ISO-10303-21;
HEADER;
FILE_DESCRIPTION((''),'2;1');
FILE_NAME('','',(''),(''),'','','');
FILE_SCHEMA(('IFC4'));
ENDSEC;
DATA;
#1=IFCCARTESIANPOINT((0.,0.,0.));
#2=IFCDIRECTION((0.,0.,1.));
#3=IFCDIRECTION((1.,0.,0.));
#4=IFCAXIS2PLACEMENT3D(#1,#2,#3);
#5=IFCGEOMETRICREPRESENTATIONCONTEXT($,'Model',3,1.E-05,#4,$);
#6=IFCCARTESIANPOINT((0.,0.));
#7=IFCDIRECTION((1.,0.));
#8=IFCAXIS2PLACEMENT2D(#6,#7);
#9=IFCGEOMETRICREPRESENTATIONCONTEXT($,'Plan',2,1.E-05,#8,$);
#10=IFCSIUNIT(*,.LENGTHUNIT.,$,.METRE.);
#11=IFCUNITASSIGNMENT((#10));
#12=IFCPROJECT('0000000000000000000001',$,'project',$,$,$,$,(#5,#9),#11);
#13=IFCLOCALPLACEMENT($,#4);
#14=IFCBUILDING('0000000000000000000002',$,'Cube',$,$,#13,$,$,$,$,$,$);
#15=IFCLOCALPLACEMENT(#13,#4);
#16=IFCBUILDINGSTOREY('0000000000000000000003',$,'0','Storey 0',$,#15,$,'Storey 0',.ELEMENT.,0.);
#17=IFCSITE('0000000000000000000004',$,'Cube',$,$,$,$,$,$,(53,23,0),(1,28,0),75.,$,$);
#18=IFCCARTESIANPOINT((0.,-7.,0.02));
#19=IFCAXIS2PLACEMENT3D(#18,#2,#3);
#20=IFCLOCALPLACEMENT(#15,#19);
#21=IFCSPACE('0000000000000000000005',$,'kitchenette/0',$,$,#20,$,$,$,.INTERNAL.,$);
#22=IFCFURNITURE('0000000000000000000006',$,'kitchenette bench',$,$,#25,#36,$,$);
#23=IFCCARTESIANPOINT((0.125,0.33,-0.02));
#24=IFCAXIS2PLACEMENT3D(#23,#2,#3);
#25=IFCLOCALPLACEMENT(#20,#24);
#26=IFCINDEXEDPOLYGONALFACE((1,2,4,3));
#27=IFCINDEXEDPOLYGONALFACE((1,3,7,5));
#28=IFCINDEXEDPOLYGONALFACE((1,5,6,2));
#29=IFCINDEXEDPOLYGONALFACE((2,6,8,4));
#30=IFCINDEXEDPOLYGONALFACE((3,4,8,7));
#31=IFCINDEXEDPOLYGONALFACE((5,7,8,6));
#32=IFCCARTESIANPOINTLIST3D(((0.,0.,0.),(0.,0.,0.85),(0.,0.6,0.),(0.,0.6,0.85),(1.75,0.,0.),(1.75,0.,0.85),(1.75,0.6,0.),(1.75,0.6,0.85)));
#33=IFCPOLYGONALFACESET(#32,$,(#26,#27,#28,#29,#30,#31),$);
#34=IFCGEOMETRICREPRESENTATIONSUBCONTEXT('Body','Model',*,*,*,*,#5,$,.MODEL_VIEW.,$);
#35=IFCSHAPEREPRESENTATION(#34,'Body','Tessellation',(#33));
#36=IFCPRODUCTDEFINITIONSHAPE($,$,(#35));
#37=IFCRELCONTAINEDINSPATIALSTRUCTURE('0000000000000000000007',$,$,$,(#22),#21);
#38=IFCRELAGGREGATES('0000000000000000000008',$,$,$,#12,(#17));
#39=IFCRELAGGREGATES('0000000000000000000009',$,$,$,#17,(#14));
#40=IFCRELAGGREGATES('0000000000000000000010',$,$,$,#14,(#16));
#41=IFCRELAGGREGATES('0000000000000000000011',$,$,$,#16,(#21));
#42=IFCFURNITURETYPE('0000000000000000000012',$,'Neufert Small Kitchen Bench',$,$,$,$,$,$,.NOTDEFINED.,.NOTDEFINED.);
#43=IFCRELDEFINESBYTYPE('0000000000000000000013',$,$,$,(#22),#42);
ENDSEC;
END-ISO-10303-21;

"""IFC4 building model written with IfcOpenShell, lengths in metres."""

from ifc_helpers import new_model, entity, si_unit, frame, origin_with_axes, origin_2d_with_axis, place, context, subcontext, project, spatial, line, indexed_curve, outline, extrude, shape, source, transform, mapped, type_object, type_shapes, element, save


model = new_model("IFC4")

# Units and contexts
model_context = context("Model", 3, precision=1e-05, world=origin_with_axes())
plan_context = context("Plan", 2, precision=1e-05, world=origin_2d_with_axis())
body_context_1 = subcontext(model_context, "Body", "Model", "MODEL_VIEW")
body_context_2 = subcontext(plan_context, "Body", "Plan", "PLAN_VIEW")
ifc_project = project(units=[si_unit("LENGTHUNIT", "METRE")], contexts=[model_context, plan_context])

# Site, building, storey
site = spatial("IfcSite", under=ifc_project, Name="Cube", RefLatitude=(53, 23, 0), RefLongitude=(1, 28, 0), RefElevation=75.0)
building_placement = place(None, origin_with_axes())
building = spatial("IfcBuilding", under=site, at=building_placement, Name="Cube")
storey_placement = place(building_placement, origin_with_axes())
storey = spatial("IfcBuildingStorey", under=building, at=storey_placement, Name="0", Description="Storey 0", LongName="Storey 0", CompositionType="ELEMENT", Elevation=0.0)

# Shared definitions
space_1_placement = place(storey_placement, frame((0.0, -7.0, 0.02), z_axis=(0.0, 0.0, 1.0), x_axis=(1.0, 0.0, 0.0)))
space_1 = spatial("IfcSpace", under=storey, at=space_1_placement, Name="kitchenette/0", PredefinedType="INTERNAL")

# Furniture
furniture_type = type_object("IfcFurnitureType", Name="Neufert Small Kitchen Bench", AssemblyPlace="NOTDEFINED", PredefinedType="NOTDEFINED")
shared_shape_1 = source(origin_with_axes(), body_context_1, "Body", "SweptSolid", [
    extrude(outline(indexed_curve([(0.0, 0.0), (1.75, 0.0), (1.75, 0.6), (0.0, 0.6)], segments=[line(1, 2, 3, 4, 1)])), origin_with_axes(), (0.0, 0.0, 1.0), 0.85),
])
shared_shape_2 = source(origin_with_axes(), body_context_2, "Body", "Curve2D", [
    entity("IfcIndexedPolyCurve", entity("IfcCartesianPointList2D", [[0.0, 0.0], [1.75, 0.0], [1.75, 0.6], [0.0, 0.6]]), [entity("IfcLineIndex", [1, 2, 3, 4, 1])]),
])
type_shapes(furniture_type, [shared_shape_1, shared_shape_2])
furniture_placement = place(space_1_placement, frame((0.125, 0.33, -0.02), z_axis=(0.0, 0.0, 1.0), x_axis=(1.0, 0.0, 0.0)))
element("IfcFurniture", 1, at=furniture_placement, inside=space_1, type_object=furniture_type, Name="kitchenette bench", shapes=[
    shape(body_context_1, "Body", "MappedRepresentation", [mapped(shared_shape_1, transform((0.0, 0.0, 0.0), x_axis=(1.0, 0.0, 0.0), y_axis=(0.0, 1.0, 0.0), z_axis=(0.0, 0.0, 1.0), scale=1.0))]),
    shape(body_context_2, "Body", "MappedRepresentation", [mapped(shared_shape_2, transform((0.0, 0.0, 0.0), x_axis=(1.0, 0.0, 0.0), y_axis=(0.0, 1.0, 0.0), z_axis=(0.0, 0.0, 1.0), scale=1.0))]),
])

save(model, "model.ifc")
